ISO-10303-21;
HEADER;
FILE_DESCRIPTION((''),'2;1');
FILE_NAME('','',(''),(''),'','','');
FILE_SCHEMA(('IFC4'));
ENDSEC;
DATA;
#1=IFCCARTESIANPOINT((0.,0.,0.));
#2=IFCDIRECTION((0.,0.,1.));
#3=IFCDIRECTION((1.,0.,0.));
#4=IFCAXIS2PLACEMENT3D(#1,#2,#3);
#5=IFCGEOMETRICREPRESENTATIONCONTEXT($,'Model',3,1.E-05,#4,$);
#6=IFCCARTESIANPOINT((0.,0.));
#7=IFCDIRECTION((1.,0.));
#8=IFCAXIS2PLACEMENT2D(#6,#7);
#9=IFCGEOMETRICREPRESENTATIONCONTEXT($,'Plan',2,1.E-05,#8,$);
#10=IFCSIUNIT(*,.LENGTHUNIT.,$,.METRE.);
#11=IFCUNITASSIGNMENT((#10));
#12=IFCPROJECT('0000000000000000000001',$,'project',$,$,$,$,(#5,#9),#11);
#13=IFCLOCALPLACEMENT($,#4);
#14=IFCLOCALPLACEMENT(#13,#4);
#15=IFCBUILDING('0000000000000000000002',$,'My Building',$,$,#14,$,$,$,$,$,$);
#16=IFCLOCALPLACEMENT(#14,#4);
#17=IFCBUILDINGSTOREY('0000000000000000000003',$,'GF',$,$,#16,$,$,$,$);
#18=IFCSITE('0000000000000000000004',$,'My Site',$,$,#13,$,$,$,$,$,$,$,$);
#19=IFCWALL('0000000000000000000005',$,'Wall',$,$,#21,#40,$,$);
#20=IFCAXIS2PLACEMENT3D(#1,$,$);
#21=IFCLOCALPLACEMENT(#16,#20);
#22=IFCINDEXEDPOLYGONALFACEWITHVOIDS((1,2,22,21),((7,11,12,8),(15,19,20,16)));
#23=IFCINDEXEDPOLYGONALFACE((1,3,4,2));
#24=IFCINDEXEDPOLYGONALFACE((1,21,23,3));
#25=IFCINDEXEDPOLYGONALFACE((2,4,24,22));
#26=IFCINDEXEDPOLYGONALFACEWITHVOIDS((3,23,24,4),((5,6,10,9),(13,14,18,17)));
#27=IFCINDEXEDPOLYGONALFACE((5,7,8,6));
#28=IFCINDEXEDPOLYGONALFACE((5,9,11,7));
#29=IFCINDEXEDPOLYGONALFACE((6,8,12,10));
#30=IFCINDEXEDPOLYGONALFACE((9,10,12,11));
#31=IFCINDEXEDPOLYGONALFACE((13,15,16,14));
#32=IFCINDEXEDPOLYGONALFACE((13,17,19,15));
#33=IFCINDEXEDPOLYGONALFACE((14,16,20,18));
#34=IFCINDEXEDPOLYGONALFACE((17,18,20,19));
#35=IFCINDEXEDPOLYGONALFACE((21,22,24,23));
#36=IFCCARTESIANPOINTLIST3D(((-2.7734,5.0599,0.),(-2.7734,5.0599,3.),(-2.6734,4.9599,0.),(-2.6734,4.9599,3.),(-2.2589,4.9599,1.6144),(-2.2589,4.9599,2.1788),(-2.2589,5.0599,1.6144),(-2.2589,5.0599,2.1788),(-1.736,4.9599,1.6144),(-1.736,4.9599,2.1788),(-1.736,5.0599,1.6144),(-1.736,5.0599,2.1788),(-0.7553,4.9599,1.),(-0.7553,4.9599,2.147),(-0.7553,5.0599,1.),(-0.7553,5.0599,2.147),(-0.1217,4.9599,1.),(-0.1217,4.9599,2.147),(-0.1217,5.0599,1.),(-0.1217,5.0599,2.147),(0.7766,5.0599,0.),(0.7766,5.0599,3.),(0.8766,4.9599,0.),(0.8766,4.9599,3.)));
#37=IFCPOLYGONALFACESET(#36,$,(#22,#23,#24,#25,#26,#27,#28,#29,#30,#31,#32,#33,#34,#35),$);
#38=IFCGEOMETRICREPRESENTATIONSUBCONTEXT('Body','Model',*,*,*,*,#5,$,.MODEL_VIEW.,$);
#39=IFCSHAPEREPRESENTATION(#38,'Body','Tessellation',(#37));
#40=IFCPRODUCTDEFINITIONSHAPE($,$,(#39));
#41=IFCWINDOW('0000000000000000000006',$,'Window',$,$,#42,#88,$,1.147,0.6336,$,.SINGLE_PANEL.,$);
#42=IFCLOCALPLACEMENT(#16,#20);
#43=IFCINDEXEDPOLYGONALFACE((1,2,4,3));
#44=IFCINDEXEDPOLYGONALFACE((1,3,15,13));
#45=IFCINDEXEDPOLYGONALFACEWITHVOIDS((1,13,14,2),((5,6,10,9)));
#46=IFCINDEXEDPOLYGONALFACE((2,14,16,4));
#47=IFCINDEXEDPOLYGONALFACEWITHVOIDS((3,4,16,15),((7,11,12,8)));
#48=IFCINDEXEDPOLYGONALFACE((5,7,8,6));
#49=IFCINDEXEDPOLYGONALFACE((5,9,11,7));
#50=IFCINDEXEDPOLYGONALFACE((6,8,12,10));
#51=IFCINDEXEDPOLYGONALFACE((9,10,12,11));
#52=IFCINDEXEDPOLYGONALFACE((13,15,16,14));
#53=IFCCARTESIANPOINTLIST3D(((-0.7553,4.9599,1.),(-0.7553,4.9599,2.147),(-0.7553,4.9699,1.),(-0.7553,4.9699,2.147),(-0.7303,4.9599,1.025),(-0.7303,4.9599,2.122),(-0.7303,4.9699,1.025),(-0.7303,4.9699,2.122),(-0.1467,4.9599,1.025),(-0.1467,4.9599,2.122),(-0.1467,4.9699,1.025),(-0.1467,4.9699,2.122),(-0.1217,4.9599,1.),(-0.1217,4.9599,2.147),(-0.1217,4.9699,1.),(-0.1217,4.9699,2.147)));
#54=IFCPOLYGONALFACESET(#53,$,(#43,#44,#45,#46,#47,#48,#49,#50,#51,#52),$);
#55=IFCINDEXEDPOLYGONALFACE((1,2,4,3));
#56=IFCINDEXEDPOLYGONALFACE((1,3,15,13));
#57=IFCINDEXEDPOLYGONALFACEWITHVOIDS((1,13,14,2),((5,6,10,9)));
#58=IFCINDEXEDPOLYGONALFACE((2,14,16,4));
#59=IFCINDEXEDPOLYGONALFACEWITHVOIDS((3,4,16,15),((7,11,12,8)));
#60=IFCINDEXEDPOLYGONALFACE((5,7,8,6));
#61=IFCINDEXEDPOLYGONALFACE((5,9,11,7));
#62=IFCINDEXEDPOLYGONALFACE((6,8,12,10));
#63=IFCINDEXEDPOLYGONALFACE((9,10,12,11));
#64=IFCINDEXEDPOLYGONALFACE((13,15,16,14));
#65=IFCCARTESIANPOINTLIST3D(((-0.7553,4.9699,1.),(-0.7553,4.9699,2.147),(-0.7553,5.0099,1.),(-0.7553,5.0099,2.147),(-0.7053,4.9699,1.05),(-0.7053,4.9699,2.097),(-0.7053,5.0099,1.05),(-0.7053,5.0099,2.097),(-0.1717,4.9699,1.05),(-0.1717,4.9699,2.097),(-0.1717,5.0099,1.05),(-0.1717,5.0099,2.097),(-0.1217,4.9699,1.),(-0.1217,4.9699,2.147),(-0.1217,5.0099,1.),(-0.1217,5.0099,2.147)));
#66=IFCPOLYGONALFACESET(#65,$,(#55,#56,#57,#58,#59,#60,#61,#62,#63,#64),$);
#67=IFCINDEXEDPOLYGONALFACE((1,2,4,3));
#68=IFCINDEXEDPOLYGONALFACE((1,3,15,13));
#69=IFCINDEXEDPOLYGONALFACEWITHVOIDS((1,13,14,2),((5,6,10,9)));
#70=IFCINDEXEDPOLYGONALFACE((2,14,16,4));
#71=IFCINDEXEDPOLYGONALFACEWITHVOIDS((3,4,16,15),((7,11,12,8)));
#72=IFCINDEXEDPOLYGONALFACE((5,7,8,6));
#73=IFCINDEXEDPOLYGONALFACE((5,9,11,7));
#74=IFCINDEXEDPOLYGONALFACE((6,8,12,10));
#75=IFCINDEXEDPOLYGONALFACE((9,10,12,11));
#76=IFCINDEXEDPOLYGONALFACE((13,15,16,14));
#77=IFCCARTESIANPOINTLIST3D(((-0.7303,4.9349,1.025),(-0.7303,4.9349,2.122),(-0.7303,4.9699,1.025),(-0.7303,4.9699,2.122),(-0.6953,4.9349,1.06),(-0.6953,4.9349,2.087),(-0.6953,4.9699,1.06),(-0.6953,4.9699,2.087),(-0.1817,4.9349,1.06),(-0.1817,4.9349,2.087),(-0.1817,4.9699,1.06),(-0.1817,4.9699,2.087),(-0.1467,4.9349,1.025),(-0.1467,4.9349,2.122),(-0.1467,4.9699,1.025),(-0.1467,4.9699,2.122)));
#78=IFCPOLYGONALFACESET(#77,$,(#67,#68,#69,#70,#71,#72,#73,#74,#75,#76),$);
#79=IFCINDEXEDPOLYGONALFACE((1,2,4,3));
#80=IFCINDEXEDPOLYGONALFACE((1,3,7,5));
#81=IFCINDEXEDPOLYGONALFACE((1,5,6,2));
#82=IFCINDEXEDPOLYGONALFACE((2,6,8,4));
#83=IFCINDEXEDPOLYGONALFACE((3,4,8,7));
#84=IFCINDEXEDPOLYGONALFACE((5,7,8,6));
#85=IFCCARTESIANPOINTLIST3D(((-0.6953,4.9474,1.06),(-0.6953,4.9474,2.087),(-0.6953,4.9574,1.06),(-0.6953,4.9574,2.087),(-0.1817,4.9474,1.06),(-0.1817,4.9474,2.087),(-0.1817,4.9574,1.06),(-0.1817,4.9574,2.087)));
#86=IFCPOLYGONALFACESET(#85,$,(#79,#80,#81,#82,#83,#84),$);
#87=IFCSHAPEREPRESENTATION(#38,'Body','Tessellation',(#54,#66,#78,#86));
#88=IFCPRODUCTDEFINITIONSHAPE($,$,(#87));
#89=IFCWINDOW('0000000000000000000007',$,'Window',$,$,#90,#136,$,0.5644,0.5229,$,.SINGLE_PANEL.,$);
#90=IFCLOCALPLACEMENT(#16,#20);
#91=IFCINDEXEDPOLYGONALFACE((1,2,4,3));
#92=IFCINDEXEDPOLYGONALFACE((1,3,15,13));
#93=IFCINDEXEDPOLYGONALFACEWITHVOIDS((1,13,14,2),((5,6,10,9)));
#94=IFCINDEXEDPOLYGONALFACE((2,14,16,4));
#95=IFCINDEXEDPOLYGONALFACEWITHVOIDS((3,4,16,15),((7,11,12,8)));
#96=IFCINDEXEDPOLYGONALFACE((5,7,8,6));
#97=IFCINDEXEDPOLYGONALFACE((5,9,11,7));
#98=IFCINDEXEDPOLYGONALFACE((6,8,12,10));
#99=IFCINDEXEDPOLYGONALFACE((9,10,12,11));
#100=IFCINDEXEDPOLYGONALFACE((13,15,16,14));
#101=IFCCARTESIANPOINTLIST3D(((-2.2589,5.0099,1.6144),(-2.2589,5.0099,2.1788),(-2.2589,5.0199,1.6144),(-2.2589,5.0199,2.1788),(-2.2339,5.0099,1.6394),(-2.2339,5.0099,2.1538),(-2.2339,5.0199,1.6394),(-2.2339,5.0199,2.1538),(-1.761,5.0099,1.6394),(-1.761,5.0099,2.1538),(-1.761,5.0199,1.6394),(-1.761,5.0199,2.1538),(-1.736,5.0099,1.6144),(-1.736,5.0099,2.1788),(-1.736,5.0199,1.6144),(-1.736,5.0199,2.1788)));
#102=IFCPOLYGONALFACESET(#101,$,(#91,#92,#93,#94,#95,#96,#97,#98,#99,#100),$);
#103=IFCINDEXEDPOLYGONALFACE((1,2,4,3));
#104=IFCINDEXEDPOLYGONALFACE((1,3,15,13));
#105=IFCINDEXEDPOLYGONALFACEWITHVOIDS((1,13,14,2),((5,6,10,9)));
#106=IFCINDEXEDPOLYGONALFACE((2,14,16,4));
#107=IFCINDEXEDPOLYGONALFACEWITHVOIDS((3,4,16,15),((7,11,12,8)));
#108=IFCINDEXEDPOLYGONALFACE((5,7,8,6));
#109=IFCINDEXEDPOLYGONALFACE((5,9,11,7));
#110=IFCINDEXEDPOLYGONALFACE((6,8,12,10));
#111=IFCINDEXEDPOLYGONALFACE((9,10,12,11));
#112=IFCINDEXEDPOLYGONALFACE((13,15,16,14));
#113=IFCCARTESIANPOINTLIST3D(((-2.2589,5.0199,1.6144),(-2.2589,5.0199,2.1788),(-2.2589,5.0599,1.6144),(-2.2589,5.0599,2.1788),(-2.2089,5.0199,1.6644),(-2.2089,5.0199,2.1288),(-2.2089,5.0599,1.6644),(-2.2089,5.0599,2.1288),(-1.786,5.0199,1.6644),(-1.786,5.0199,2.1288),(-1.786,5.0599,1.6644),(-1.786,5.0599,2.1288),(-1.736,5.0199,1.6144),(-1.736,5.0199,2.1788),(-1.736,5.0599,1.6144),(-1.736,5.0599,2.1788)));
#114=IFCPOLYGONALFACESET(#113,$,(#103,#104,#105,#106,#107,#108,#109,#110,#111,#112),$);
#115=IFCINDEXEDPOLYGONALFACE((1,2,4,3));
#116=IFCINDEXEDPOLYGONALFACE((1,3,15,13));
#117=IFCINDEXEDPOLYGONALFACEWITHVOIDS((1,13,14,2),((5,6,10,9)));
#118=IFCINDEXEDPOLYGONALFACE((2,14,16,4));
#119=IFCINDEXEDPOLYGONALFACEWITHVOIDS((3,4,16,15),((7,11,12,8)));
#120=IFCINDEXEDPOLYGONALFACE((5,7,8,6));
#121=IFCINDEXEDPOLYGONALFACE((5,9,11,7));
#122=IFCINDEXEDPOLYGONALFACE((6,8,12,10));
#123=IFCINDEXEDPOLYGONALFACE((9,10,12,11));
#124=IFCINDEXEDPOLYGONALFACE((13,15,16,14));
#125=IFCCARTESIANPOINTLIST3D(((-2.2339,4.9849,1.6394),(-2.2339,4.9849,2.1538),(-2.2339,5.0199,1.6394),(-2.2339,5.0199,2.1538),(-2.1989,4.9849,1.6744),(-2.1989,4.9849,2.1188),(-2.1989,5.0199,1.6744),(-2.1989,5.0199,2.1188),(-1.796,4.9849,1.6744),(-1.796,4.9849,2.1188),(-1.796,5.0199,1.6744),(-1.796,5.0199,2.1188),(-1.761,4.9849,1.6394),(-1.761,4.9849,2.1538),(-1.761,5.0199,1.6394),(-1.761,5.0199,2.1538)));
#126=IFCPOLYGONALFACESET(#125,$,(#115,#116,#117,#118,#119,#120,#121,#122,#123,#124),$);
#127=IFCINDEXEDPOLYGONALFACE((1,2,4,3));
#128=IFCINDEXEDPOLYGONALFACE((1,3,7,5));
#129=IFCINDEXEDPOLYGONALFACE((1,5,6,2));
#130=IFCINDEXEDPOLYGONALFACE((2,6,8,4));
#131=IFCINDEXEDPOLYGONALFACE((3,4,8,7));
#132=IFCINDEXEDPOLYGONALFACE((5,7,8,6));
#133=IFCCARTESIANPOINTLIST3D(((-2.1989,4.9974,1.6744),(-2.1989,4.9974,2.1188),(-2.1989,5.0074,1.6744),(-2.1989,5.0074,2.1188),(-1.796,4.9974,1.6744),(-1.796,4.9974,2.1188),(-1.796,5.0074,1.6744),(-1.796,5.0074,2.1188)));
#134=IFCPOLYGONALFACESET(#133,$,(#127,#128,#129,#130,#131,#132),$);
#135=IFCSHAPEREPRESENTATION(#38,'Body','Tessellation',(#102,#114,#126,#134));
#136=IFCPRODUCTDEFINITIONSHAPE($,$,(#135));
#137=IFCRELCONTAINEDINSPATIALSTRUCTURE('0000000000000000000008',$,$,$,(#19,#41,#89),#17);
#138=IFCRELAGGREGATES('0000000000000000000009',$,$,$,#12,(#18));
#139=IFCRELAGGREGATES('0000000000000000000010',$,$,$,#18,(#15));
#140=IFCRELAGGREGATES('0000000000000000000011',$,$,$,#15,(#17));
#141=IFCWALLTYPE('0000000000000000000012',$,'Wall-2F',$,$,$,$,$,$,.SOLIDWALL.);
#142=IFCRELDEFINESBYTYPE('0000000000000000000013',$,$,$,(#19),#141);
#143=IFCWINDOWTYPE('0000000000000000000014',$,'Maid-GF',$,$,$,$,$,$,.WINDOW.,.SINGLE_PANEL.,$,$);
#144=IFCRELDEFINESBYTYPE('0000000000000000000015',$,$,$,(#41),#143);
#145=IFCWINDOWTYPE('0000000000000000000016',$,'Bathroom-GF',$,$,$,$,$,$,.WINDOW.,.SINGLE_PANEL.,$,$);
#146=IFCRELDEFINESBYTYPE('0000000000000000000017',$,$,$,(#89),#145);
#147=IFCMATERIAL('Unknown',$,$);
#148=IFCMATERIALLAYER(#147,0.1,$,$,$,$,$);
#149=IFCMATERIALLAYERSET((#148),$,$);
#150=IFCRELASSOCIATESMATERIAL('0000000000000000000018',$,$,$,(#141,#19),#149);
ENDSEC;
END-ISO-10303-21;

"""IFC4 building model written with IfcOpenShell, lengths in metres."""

from ifc_helpers import new_model, entity, si_unit, frame, origin_with_axes, origin_2d_with_axis, place, context, subcontext, project, spatial, line, indexed_curve, outline, extrude, shape, source, transform, mapped, material, layer, layer_set, layer_usage, type_object, type_shapes, element, fill, save


model = new_model("IFC4")

# Units and contexts
model_context = context("Model", 3, precision=1e-05, world=origin_with_axes())
plan_context = context("Plan", 2, precision=1e-05, world=origin_2d_with_axis())
body_context_1 = subcontext(model_context, "Body", "Model", "MODEL_VIEW")
body_context_2 = subcontext(plan_context, "Body", "Plan", "PLAN_VIEW")
ifc_project = project(units=[si_unit("LENGTHUNIT", "METRE")], contexts=[model_context, plan_context])

# Site, building, storey
site_placement = place(None, origin_with_axes())
site = spatial("IfcSite", under=ifc_project, at=site_placement, Name="My Site")
building_placement = place(site_placement, origin_with_axes())
building = spatial("IfcBuilding", under=site, at=building_placement, Name="My Building")
storey_placement = place(building_placement, origin_with_axes())
storey = spatial("IfcBuildingStorey", under=building, at=storey_placement, Name="GF")

# Shared definitions
ifc_material = material(Name="Unknown")

# Shared definitions
ifc_layer_1 = layer(ifc_material, 0.1)
ifc_layer_set_1 = layer_set([ifc_layer_1])
wall_type = type_object("IfcWallType", Name="Wall-2F", PredefinedType="SOLIDWALL", material=ifc_layer_set_1)

# Wall, openings, windows
ifc_layer_usage_1 = layer_usage(ifc_layer_set_1, "AXIS2", "POSITIVE", 0.0)
wall_1_placement = place(storey_placement, frame((0.7766, 5.0599, 0.0), z_axis=(0.0, 0.0, 1.0), x_axis=(-1.0, 0.0, 0.0)))
wall_1 = element("IfcWall", 1, at=wall_1_placement, inside=storey, type_object=wall_type, material=ifc_layer_usage_1, Name="Wall", context=body_context_1, shape_type="SweptSolid", body=[
    extrude(outline(indexed_curve([(0.0, 0.0), (-0.1, 0.1), (3.45, 0.1), (3.55, 0.0)], segments=[line(1, 2, 3, 4, 1)])), origin_with_axes(), (0.0, 0.0, 1.0), 3.0),
])
shared_shape_1 = source(origin_with_axes(), body_context_1, "Body", "SweptSolid", [
    extrude(outline(indexed_curve([(0.0, 0.0), (0.6336, 0.0), (0.6336, 1.147), (0.0, 1.147)], segments=[line(1, 2, 3, 4, 1)])), frame((0.0, -0.6, 0.0), z_axis=(0.0, -1.0, 0.0), x_axis=(1.0, 0.0, 0.0)), (0.0, 0.0, -1.0), 1.2),
])
opening_1_placement = place(wall_1_placement, frame((0.8983, 0.0, 1.0), z_axis=(0.0, 0.0, 1.0), x_axis=(1.0, 0.0, 0.0)))
opening_1 = element("IfcOpeningElement", 2, at=opening_1_placement, cuts=wall_1, PredefinedType="OPENING", context=body_context_1, shape_type="MappedRepresentation", body=[
    mapped(shared_shape_1, transform((0.0, 0.0, 0.0), x_axis=(1.0, 0.0, 0.0), y_axis=(0.0, 1.0, 0.0), z_axis=(0.0, 0.0, 1.0), scale=1.0)),
])
shared_shape_2 = source(origin_with_axes(), body_context_1, "Body", "SweptSolid", [
    extrude(outline(indexed_curve([(0.0, 0.0), (0.5229, 0.0), (0.5229, 0.5644), (0.0, 0.5644)], segments=[line(1, 2, 3, 4, 1)])), frame((0.0, -0.6, 0.0), z_axis=(0.0, -1.0, 0.0), x_axis=(1.0, 0.0, 0.0)), (0.0, 0.0, -1.0), 1.2),
])
opening_2_placement = place(wall_1_placement, frame((2.5126, -0.05, 1.6144), z_axis=(0.0, 0.0, 1.0), x_axis=(1.0, 0.0, 0.0)))
opening_2 = element("IfcOpeningElement", 3, at=opening_2_placement, cuts=wall_1, PredefinedType="OPENING", context=body_context_1, shape_type="MappedRepresentation", body=[
    mapped(shared_shape_2, transform((0.0, 0.0, 0.0), x_axis=(1.0, 0.0, 0.0), y_axis=(0.0, 1.0, 0.0), z_axis=(0.0, 0.0, 1.0), scale=1.0)),
])
window_type_1 = type_object("IfcWindowType", Name="Maid-GF", PartitioningType="SINGLE_PANEL", PredefinedType="WINDOW")
shared_shape_3 = source(origin_with_axes(), body_context_1, "Body", "SweptSolid", [
    extrude(outline(indexed_curve([(0.0, 0.0), (0.6336, 0.0), (0.6336, 1.147), (0.0, 1.147)], segments=[line(1, 2, 3, 4, 1)]), holes=[indexed_curve([(0.025, 0.025), (0.6086, 0.025), (0.6086, 1.122), (0.025, 1.122)], segments=[line(1, 2, 3, 4, 1)])]), frame((0.0, 0.09, 0.0), z_axis=(0.0, -1.0, 0.0), x_axis=(1.0, 0.0, 0.0)), (0.0, 0.0, -1.0), 0.01),
    extrude(outline(indexed_curve([(0.0, 0.0), (0.6336, 0.0), (0.6336, 1.147), (0.0, 1.147)], segments=[line(1, 2, 3, 4, 1)]), holes=[indexed_curve([(0.05, 0.05), (0.5836, 0.05), (0.5836, 1.097), (0.05, 1.097)], segments=[line(1, 2, 3, 4, 1)])]), frame((0.0, 0.05, 0.0), z_axis=(0.0, -1.0, 0.0), x_axis=(1.0, 0.0, 0.0)), (0.0, 0.0, -1.0), 0.04),
    extrude(outline(indexed_curve([(0.0, 0.0), (0.5836, 0.0), (0.5836, 1.097), (0.0, 1.097)], segments=[line(1, 2, 3, 4, 1)]), holes=[indexed_curve([(0.035, 0.035), (0.5486, 0.035), (0.5486, 1.062), (0.035, 1.062)], segments=[line(1, 2, 3, 4, 1)])]), frame((0.025, 0.09, 0.025), z_axis=(0.0, -1.0, 0.0), x_axis=(1.0, 0.0, 0.0)), (0.0, 0.0, -1.0), 0.035),
    extrude(outline(indexed_curve([(0.035, 0.035), (0.5486, 0.035), (0.5486, 1.062), (0.035, 1.062)], segments=[line(1, 2, 3, 4, 1)])), frame((0.025, 0.1025, 0.025), z_axis=(0.0, -1.0, 0.0), x_axis=(1.0, 0.0, 0.0)), (0.0, 0.0, -1.0), 0.01),
])
shared_shape_4 = source(origin_with_axes(), body_context_2, "Body", "Curve2D", [
    entity("IfcIndexedPolyCurve", entity("IfcCartesianPointList2D", [[0.05, 0.05], [0.5836, 0.05]])),
    entity("IfcIndexedPolyCurve", entity("IfcCartesianPointList2D", [[0.0, 0.1], [0.025, 0.1], [0.025, 0.09], [0.05, 0.09], [0.05, 0.05], [0.0, 0.05]]), [entity("IfcLineIndex", [1, 2, 3, 4, 5, 6, 1])]),
    entity("IfcIndexedPolyCurve", entity("IfcCartesianPointList2D", [[0.6336, 0.1], [0.6086, 0.1], [0.6086, 0.09], [0.5836, 0.09], [0.5836, 0.05], [0.6336, 0.05]]), [entity("IfcLineIndex", [1, 2, 3, 4, 5, 6, 1])]),
    entity("IfcIndexedPolyCurve", entity("IfcCartesianPointList2D", [[0.025, 0.09], [0.06, 0.09], [0.06, 0.125], [0.025, 0.125]]), [entity("IfcLineIndex", [1, 2, 3, 4, 1])]),
    entity("IfcIndexedPolyCurve", entity("IfcCartesianPointList2D", [[0.6086, 0.09], [0.5736, 0.09], [0.5736, 0.125], [0.6086, 0.125]]), [entity("IfcLineIndex", [1, 2, 3, 4, 1])]),
    entity("IfcIndexedPolyCurve", entity("IfcCartesianPointList2D", [[0.06, 0.09], [0.5736, 0.09]])),
    entity("IfcIndexedPolyCurve", entity("IfcCartesianPointList2D", [[0.06, 0.125], [0.5736, 0.125]])),
    entity("IfcIndexedPolyCurve", entity("IfcCartesianPointList2D", [[0.06, 0.1075], [0.5736, 0.1075]])),
])
type_shapes(window_type_1, [shared_shape_3, shared_shape_4])
window_1_placement = place(opening_1_placement, frame((0.0, 0.0, 0.0), z_axis=(0.0, 0.0, 1.0), x_axis=(1.0, 0.0, 0.0)))
window_1 = element("IfcWindow", 4, at=window_1_placement, inside=storey, type_object=window_type_1, Name="Window", OverallHeight=1.147, OverallWidth=0.6336, PartitioningType="SINGLE_PANEL", shapes=[
    shape(body_context_1, "Body", "MappedRepresentation", [mapped(shared_shape_3, transform((0.0, 0.0, 0.0), x_axis=(1.0, 0.0, 0.0), y_axis=(0.0, 1.0, 0.0), z_axis=(0.0, 0.0, 1.0), scale=1.0))]),
    shape(body_context_2, "Body", "MappedRepresentation", [mapped(shared_shape_4, transform((0.0, 0.0, 0.0), x_axis=(1.0, 0.0, 0.0), y_axis=(0.0, 1.0, 0.0), z_axis=(0.0, 0.0, 1.0), scale=1.0))]),
])
fill(opening_1, window_1)
window_type_2 = type_object("IfcWindowType", Name="Bathroom-GF", PartitioningType="SINGLE_PANEL", PredefinedType="WINDOW")
shared_shape_5 = source(origin_with_axes(), body_context_1, "Body", "SweptSolid", [
    extrude(outline(indexed_curve([(0.0, 0.0), (0.5229, 0.0), (0.5229, 0.5644), (0.0, 0.5644)], segments=[line(1, 2, 3, 4, 1)]), holes=[indexed_curve([(0.025, 0.025), (0.4979, 0.025), (0.4979, 0.5394), (0.025, 0.5394)], segments=[line(1, 2, 3, 4, 1)])]), frame((0.0, 0.09, 0.0), z_axis=(0.0, -1.0, 0.0), x_axis=(1.0, 0.0, 0.0)), (0.0, 0.0, -1.0), 0.01),
    extrude(outline(indexed_curve([(0.0, 0.0), (0.5229, 0.0), (0.5229, 0.5644), (0.0, 0.5644)], segments=[line(1, 2, 3, 4, 1)]), holes=[indexed_curve([(0.05, 0.05), (0.4729, 0.05), (0.4729, 0.5144), (0.05, 0.5144)], segments=[line(1, 2, 3, 4, 1)])]), frame((0.0, 0.05, 0.0), z_axis=(0.0, -1.0, 0.0), x_axis=(1.0, 0.0, 0.0)), (0.0, 0.0, -1.0), 0.04),
    extrude(outline(indexed_curve([(0.0, 0.0), (0.4729, 0.0), (0.4729, 0.5144), (0.0, 0.5144)], segments=[line(1, 2, 3, 4, 1)]), holes=[indexed_curve([(0.035, 0.035), (0.4379, 0.035), (0.4379, 0.4794), (0.035, 0.4794)], segments=[line(1, 2, 3, 4, 1)])]), frame((0.025, 0.09, 0.025), z_axis=(0.0, -1.0, 0.0), x_axis=(1.0, 0.0, 0.0)), (0.0, 0.0, -1.0), 0.035),
    extrude(outline(indexed_curve([(0.035, 0.035), (0.4379, 0.035), (0.4379, 0.4794), (0.035, 0.4794)], segments=[line(1, 2, 3, 4, 1)])), frame((0.025, 0.1025, 0.025), z_axis=(0.0, -1.0, 0.0), x_axis=(1.0, 0.0, 0.0)), (0.0, 0.0, -1.0), 0.01),
])
shared_shape_6 = source(origin_with_axes(), body_context_2, "Body", "Curve2D", [
    entity("IfcIndexedPolyCurve", entity("IfcCartesianPointList2D", [[0.05, 0.05], [0.4729, 0.05]])),
    entity("IfcIndexedPolyCurve", entity("IfcCartesianPointList2D", [[0.0, 0.1], [0.025, 0.1], [0.025, 0.09], [0.05, 0.09], [0.05, 0.05], [0.0, 0.05]]), [entity("IfcLineIndex", [1, 2, 3, 4, 5, 6, 1])]),
    entity("IfcIndexedPolyCurve", entity("IfcCartesianPointList2D", [[0.5229, 0.1], [0.4979, 0.1], [0.4979, 0.09], [0.4729, 0.09], [0.4729, 0.05], [0.5229, 0.05]]), [entity("IfcLineIndex", [1, 2, 3, 4, 5, 6, 1])]),
    entity("IfcIndexedPolyCurve", entity("IfcCartesianPointList2D", [[0.025, 0.09], [0.06, 0.09], [0.06, 0.125], [0.025, 0.125]]), [entity("IfcLineIndex", [1, 2, 3, 4, 1])]),
    entity("IfcIndexedPolyCurve", entity("IfcCartesianPointList2D", [[0.4979, 0.09], [0.4629, 0.09], [0.4629, 0.125], [0.4979, 0.125]]), [entity("IfcLineIndex", [1, 2, 3, 4, 1])]),
    entity("IfcIndexedPolyCurve", entity("IfcCartesianPointList2D", [[0.06, 0.09], [0.4629, 0.09]])),
    entity("IfcIndexedPolyCurve", entity("IfcCartesianPointList2D", [[0.06, 0.125], [0.4629, 0.125]])),
    entity("IfcIndexedPolyCurve", entity("IfcCartesianPointList2D", [[0.06, 0.1075], [0.4629, 0.1075]])),
])
type_shapes(window_type_2, [shared_shape_5, shared_shape_6])
window_2_placement = place(opening_2_placement, frame((0.0, 0.0, 0.0), z_axis=(0.0, 0.0, 1.0), x_axis=(1.0, 0.0, 0.0)))
window_2 = element("IfcWindow", 5, at=window_2_placement, inside=storey, type_object=window_type_2, Name="Window", OverallHeight=0.5644, OverallWidth=0.5229, PartitioningType="SINGLE_PANEL", shapes=[
    shape(body_context_1, "Body", "MappedRepresentation", [mapped(shared_shape_5, transform((0.0, 0.0, 0.0), x_axis=(1.0, 0.0, 0.0), y_axis=(0.0, 1.0, 0.0), z_axis=(0.0, 0.0, 1.0), scale=1.0))]),
    shape(body_context_2, "Body", "MappedRepresentation", [mapped(shared_shape_6, transform((0.0, 0.0, 0.0), x_axis=(1.0, 0.0, 0.0), y_axis=(0.0, 1.0, 0.0), z_axis=(0.0, 0.0, 1.0), scale=1.0))]),
])
fill(opening_2, window_2)

save(model, "model.ifc")
